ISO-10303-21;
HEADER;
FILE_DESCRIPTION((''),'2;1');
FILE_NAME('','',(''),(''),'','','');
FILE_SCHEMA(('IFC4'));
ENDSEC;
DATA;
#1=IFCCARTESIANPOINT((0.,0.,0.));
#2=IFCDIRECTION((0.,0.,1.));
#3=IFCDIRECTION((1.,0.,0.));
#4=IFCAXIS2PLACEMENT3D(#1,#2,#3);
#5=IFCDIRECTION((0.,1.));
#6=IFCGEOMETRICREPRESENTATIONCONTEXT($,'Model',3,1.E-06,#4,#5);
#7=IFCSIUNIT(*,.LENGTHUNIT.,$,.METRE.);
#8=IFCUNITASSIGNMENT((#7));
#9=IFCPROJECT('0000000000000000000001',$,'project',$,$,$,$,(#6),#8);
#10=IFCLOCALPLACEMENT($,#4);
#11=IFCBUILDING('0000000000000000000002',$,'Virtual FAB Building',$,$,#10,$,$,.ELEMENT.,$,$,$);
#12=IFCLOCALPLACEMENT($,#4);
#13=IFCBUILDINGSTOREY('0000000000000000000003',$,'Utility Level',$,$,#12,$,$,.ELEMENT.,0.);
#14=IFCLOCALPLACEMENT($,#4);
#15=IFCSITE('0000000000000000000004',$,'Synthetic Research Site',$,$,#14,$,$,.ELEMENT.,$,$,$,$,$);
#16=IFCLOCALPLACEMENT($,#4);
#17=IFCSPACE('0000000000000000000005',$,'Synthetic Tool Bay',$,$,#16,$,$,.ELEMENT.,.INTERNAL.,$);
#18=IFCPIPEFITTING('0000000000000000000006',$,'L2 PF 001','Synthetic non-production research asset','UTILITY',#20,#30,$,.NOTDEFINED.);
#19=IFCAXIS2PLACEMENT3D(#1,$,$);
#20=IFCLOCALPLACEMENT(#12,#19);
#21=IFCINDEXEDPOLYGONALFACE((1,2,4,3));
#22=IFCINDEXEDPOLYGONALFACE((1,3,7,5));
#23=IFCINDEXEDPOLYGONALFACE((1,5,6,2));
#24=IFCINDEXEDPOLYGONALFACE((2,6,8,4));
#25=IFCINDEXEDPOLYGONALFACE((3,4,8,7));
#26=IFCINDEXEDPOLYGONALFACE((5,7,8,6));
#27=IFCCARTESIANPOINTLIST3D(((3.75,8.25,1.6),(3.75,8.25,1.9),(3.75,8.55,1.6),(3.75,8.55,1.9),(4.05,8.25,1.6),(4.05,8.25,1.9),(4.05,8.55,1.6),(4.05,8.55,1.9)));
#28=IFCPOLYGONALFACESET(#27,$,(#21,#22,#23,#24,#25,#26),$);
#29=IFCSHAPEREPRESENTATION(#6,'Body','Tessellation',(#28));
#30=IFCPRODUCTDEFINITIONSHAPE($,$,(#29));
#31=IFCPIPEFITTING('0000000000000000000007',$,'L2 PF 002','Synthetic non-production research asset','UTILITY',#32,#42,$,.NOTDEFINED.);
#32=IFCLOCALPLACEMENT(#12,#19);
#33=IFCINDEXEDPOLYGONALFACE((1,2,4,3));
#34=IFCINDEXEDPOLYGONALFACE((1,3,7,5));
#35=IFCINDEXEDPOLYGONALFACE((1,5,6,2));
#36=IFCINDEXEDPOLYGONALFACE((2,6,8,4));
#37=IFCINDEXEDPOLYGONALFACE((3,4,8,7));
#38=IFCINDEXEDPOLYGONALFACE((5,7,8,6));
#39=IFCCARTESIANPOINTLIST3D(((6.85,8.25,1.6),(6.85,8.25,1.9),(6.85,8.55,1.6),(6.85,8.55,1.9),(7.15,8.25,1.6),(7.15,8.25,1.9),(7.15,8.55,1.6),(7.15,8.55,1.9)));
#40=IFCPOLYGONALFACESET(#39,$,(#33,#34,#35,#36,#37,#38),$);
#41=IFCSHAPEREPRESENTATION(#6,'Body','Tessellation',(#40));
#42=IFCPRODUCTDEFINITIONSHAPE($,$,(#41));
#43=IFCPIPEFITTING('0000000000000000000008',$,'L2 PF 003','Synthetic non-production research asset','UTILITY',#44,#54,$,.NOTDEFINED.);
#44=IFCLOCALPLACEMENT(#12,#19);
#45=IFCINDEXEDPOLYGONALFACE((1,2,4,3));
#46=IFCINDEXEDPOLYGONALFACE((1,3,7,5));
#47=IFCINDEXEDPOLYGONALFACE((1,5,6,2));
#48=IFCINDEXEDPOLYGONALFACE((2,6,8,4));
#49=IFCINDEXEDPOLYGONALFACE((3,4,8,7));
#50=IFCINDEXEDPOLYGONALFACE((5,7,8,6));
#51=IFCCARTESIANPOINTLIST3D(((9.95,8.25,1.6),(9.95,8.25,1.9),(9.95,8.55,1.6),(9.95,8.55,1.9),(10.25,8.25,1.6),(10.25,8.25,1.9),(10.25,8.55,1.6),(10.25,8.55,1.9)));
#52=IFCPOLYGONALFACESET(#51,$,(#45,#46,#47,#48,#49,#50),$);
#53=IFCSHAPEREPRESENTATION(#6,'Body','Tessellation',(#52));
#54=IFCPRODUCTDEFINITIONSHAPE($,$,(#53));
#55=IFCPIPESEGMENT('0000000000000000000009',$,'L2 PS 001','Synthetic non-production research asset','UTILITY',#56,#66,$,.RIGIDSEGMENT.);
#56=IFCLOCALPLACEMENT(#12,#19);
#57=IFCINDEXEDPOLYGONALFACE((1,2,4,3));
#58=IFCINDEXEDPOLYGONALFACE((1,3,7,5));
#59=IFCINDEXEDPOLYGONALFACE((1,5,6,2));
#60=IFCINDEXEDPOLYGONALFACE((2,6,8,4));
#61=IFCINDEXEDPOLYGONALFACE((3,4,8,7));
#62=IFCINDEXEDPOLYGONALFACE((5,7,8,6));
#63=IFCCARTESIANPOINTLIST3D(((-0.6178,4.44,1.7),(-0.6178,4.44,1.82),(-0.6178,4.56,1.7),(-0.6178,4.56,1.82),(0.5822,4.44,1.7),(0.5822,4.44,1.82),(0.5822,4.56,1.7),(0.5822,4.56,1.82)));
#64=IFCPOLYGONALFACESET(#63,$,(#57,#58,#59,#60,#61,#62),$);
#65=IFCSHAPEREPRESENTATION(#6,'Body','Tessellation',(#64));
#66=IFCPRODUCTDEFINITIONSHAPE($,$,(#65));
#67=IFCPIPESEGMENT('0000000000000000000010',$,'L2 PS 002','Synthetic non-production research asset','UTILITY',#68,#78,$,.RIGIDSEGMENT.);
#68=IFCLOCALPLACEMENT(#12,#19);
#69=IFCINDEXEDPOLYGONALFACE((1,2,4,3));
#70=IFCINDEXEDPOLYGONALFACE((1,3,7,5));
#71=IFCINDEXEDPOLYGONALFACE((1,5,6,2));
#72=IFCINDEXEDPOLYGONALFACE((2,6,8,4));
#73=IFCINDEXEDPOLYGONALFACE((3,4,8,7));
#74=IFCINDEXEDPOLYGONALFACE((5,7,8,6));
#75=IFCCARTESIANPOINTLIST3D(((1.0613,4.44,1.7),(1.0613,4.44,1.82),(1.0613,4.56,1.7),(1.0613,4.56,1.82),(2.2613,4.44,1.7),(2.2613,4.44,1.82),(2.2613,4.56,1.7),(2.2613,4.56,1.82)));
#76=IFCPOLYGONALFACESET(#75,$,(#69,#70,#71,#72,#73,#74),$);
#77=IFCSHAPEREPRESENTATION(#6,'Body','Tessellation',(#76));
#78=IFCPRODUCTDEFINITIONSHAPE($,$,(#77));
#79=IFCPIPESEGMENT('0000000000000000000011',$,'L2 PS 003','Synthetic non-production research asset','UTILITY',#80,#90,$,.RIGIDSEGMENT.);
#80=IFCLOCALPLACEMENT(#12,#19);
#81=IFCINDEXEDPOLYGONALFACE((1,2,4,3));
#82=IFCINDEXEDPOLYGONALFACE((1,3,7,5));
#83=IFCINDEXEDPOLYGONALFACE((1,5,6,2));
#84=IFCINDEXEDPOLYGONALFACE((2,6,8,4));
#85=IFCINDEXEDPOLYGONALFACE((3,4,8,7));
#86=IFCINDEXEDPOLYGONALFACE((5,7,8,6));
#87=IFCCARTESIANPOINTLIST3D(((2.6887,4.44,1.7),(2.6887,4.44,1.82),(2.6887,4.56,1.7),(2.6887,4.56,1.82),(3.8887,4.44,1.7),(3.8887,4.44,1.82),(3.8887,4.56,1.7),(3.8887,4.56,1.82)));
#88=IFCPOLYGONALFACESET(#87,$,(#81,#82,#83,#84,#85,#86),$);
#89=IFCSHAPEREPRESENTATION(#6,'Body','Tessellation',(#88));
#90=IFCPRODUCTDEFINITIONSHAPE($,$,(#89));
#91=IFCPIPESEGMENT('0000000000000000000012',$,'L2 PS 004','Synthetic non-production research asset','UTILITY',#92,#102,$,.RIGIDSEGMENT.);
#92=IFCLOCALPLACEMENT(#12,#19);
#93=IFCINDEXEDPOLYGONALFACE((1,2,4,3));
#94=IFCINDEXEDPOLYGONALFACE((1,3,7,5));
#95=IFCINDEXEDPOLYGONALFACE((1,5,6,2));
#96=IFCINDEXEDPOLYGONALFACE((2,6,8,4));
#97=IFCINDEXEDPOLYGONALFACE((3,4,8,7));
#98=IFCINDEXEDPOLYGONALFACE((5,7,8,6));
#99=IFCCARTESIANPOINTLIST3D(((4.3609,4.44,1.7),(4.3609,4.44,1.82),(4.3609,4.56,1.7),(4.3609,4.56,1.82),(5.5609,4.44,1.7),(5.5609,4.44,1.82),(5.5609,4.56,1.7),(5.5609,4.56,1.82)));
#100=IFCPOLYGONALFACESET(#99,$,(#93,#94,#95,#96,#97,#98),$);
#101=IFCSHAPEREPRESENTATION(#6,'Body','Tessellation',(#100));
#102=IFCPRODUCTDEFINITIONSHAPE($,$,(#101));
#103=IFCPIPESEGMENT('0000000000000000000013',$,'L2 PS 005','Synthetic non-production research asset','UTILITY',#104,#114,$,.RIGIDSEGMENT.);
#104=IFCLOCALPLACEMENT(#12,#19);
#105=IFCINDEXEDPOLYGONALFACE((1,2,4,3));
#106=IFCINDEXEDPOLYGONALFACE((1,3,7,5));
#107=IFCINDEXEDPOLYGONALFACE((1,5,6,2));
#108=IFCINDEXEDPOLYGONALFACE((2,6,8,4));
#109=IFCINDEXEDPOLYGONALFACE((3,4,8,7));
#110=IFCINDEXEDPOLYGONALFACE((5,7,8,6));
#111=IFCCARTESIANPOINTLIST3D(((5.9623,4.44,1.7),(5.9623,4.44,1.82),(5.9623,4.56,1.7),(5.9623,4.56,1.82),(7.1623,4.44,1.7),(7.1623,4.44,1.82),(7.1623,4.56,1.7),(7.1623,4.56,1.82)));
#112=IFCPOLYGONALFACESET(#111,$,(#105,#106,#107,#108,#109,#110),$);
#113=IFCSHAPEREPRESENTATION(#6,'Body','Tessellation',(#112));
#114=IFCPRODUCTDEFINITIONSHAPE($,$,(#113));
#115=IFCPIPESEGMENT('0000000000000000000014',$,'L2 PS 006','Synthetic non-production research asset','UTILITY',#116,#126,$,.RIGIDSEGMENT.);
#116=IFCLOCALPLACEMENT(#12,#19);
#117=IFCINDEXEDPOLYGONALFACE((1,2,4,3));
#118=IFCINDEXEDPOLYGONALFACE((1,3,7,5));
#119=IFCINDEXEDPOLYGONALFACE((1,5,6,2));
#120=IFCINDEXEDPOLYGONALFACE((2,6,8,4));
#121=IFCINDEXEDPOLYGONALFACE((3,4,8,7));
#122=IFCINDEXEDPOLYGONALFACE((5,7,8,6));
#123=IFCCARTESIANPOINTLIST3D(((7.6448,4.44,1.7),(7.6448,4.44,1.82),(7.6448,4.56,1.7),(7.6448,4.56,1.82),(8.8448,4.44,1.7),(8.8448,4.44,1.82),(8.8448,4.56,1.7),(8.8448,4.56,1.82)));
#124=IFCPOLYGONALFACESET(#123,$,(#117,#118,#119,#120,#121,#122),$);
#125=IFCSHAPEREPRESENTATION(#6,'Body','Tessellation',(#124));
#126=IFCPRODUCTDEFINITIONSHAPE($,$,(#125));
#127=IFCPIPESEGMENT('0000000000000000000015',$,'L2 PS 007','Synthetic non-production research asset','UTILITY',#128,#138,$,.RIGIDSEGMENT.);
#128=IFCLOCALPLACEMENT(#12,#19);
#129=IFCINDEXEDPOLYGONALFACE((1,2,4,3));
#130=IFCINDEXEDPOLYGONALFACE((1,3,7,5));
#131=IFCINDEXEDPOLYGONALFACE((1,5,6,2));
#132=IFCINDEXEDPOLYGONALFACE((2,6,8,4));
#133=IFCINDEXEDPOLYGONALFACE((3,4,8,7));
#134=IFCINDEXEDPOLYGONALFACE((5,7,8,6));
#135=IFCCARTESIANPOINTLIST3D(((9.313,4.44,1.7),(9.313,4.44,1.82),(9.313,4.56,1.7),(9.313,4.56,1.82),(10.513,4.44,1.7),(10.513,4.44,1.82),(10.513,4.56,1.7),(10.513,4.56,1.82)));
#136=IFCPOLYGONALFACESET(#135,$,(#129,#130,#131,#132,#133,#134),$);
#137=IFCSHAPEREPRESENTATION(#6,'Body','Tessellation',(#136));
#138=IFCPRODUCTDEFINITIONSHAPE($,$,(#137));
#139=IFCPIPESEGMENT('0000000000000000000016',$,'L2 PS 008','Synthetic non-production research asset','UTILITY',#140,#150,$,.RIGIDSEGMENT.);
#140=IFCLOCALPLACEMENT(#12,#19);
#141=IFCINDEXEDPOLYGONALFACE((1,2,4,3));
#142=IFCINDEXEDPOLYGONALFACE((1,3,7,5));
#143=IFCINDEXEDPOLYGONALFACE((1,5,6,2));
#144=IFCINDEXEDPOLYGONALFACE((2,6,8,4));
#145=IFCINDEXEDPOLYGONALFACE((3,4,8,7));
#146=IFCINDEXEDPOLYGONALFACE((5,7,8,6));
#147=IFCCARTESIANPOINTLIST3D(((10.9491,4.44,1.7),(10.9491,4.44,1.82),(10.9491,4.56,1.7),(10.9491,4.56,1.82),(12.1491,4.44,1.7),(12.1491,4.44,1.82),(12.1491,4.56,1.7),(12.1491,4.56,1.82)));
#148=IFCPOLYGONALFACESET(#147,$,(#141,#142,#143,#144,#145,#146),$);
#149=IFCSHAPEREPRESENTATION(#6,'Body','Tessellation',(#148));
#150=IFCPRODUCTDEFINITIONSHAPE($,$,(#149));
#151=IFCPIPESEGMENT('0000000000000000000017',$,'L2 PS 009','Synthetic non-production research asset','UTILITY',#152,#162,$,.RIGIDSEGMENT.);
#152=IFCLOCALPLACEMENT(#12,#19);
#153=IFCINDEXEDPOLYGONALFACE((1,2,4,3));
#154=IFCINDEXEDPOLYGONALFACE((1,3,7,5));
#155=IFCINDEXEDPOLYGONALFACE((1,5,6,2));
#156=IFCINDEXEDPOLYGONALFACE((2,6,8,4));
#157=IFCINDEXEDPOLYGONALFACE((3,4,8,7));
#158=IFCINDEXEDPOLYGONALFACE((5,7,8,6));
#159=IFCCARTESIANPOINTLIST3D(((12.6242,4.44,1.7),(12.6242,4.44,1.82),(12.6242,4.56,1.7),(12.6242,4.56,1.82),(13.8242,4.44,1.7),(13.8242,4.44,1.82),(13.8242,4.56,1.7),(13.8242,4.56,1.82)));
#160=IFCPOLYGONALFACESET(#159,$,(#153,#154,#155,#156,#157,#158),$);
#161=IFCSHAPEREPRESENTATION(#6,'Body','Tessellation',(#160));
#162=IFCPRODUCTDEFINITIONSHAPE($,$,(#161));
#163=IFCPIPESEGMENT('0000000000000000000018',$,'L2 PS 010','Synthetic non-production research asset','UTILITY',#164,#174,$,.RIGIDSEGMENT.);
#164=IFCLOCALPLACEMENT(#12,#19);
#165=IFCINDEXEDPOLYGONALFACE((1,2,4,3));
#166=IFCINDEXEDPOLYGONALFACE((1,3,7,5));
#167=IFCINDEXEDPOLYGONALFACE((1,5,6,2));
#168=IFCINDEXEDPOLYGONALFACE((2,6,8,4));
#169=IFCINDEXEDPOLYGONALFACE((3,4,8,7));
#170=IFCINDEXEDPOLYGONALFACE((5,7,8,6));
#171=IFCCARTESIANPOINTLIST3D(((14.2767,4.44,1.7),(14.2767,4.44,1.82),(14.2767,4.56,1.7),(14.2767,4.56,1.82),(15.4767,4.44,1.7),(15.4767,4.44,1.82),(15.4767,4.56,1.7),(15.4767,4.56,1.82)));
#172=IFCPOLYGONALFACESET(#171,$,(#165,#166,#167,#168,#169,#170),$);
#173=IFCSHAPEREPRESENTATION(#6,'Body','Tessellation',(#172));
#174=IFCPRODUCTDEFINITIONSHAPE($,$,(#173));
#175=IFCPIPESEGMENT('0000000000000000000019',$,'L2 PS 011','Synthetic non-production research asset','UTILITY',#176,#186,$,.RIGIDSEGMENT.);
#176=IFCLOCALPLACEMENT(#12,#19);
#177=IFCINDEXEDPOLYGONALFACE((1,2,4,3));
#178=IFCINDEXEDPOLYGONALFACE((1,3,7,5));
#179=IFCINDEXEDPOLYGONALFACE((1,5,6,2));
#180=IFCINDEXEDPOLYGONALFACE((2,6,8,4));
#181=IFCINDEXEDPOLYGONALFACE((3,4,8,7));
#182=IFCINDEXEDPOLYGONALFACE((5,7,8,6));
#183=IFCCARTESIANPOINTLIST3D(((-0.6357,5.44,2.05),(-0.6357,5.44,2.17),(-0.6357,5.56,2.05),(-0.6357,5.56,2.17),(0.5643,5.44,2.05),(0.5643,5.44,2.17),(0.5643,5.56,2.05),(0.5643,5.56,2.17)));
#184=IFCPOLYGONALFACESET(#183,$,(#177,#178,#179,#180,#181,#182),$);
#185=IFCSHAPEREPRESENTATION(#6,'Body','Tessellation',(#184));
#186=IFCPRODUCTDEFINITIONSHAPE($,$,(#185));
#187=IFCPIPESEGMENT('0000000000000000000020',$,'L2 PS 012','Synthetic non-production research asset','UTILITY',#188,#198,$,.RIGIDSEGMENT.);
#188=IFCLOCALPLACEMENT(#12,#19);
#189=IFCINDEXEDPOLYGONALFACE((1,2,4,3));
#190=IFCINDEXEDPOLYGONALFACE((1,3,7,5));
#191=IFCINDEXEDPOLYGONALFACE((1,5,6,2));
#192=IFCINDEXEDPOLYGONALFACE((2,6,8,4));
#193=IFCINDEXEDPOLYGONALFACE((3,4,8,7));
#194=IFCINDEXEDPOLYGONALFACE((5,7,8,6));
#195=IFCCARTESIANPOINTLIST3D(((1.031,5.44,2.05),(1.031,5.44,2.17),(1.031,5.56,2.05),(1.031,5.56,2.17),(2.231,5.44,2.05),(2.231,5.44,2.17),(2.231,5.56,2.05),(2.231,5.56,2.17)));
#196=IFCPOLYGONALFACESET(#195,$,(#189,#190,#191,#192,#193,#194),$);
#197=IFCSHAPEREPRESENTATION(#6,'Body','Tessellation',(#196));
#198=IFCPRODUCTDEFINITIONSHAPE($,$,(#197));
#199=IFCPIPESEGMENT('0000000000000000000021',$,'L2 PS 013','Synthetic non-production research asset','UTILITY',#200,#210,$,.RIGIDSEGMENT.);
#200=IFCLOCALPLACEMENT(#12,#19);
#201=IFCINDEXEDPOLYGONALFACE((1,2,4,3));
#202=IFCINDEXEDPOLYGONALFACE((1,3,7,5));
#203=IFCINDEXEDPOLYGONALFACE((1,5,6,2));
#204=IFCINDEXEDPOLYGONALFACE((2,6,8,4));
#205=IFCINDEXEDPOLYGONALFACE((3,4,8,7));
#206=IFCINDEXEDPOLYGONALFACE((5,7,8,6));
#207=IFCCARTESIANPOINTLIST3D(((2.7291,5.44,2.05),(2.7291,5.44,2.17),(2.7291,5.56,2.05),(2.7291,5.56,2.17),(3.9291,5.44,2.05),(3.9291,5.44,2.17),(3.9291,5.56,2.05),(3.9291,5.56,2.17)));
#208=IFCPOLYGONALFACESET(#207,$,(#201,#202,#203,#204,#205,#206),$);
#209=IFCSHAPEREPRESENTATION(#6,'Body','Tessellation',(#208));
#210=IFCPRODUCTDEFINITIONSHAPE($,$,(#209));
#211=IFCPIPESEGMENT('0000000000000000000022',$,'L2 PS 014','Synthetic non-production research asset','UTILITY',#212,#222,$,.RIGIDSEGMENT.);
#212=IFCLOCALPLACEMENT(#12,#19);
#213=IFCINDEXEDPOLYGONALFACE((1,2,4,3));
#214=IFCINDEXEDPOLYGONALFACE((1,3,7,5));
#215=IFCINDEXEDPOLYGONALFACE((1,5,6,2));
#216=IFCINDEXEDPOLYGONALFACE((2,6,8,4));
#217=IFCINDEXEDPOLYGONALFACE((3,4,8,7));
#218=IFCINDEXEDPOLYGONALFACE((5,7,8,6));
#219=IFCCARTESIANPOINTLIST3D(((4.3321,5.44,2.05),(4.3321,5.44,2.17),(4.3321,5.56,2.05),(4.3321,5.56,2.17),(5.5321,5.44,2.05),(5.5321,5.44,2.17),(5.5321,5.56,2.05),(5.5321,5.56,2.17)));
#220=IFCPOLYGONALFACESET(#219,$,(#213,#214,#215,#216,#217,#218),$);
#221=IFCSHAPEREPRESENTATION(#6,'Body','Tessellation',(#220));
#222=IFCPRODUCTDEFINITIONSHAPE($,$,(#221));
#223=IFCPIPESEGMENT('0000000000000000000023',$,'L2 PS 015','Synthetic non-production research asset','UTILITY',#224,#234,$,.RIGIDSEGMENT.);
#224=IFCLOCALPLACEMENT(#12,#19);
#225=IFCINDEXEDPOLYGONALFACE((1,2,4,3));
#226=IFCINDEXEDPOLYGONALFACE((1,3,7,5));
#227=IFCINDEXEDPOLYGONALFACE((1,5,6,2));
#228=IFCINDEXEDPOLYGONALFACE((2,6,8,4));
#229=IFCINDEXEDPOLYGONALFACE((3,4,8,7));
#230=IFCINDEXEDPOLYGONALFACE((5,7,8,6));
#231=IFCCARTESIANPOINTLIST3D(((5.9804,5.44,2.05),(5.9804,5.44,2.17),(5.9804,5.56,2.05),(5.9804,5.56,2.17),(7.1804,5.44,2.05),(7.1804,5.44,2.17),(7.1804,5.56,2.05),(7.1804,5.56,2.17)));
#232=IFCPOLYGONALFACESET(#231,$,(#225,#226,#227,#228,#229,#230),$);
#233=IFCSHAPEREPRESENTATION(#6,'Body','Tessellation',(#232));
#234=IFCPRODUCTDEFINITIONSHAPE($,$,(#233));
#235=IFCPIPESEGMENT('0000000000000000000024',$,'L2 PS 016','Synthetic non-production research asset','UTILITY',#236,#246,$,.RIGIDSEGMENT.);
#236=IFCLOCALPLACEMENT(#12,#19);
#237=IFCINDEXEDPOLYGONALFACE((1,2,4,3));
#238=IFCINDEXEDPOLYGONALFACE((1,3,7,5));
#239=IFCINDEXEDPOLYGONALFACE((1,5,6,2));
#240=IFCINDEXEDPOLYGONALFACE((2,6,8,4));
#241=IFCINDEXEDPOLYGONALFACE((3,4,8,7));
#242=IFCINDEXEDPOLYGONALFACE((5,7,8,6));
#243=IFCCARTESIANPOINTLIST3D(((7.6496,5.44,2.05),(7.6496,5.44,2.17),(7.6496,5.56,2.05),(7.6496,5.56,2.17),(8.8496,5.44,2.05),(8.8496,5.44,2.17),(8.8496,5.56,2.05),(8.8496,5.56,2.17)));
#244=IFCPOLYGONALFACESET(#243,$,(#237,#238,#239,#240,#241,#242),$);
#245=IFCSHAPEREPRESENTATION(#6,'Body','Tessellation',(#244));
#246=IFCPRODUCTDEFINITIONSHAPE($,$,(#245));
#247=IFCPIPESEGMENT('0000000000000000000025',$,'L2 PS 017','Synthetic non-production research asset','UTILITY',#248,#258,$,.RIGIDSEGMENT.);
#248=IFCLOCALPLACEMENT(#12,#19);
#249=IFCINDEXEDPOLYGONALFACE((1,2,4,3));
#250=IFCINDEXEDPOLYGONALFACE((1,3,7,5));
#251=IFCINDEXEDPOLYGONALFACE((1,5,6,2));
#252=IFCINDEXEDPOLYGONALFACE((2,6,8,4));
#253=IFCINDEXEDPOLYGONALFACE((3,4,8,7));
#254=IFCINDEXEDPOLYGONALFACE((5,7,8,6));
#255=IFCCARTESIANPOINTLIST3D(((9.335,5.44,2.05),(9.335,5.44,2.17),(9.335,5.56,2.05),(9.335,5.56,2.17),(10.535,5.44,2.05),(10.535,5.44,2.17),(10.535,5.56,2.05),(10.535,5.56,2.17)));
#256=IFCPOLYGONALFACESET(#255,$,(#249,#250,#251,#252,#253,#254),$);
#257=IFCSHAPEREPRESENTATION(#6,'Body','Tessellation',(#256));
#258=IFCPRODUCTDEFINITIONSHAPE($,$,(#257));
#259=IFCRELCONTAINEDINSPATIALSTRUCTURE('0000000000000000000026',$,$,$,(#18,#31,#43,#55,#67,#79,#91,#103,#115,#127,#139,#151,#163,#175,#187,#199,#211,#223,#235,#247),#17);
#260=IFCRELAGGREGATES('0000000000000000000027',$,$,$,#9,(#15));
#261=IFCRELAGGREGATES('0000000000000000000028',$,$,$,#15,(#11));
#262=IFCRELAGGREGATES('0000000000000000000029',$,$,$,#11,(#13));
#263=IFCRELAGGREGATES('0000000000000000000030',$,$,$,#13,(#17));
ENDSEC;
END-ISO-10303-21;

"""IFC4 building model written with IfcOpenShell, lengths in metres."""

from ifc_helpers import new_model, si_unit, direction, frame, origin_with_axes, origin_2d_with_axis, place, context, project, spatial, rectangle, extrude, element, save


model = new_model("IFC4")

# Units and contexts
model_context = context("Model", 3, precision=1e-06, world=origin_with_axes(), true_north=direction((0.0, 1.0)))
ifc_project = project(units=[si_unit("LENGTHUNIT", "METRE")], contexts=[model_context])

# Site, building, storey, space
site_placement = place(None, origin_with_axes())
site = spatial("IfcSite", under=ifc_project, at=site_placement, Name="Synthetic Research Site", CompositionType="ELEMENT")
building_placement = place(None, origin_with_axes())
building = spatial("IfcBuilding", under=site, at=building_placement, Name="Virtual FAB Building", CompositionType="ELEMENT")
storey_placement = place(None, origin_with_axes())
storey = spatial("IfcBuildingStorey", under=building, at=storey_placement, Name="Utility Level", CompositionType="ELEMENT", Elevation=0.0)
space_placement = place(None, origin_with_axes())
space = spatial("IfcSpace", under=storey, at=space_placement, Name="Synthetic Tool Bay", CompositionType="ELEMENT", PredefinedType="INTERNAL")

# Pipe fittings
for number, where, z_axis, x_axis, name in (
    (1, (3.9, 8.4, 1.6), (0.0, 0.0, 1.0), (1.0, 0.0, 0.0), "L2 PF 001"),
    (2, (7.0, 8.4, 1.6), (0.0, 0.0, 1.0), (1.0, 0.0, 0.0), "L2 PF 002"),
    (3, (10.1, 8.4, 1.6), (0.0, 0.0, 1.0), (1.0, 0.0, 0.0), "L2 PF 003"),
):
    element("IfcPipeFitting", number, at=place(None, frame(where, z_axis=z_axis, x_axis=x_axis)), inside=space, Name=name, Description="Synthetic non-production research asset", ObjectType="UTILITY", PredefinedType="NOTDEFINED", context=model_context, shape_type="SweptSolid", body=[
        extrude(rectangle(XDim=0.3, YDim=0.3, at=origin_2d_with_axis()), origin_with_axes(), (0.0, 0.0, 1.0), 0.3),
    ])

# Pipe segments
for number, where, z_axis, x_axis, name in (
    (4, (-0.0178, 4.5, 1.7), (0.0, 0.0, 1.0), (1.0, 0.0, 0.0), "L2 PS 001"),
    (5, (1.6613, 4.5, 1.7), (0.0, 0.0, 1.0), (1.0, 0.0, 0.0), "L2 PS 002"),
    (6, (3.2887, 4.5, 1.7), (0.0, 0.0, 1.0), (1.0, 0.0, 0.0), "L2 PS 003"),
    (7, (4.9609, 4.5, 1.7), (0.0, 0.0, 1.0), (1.0, 0.0, 0.0), "L2 PS 004"),
    (8, (6.5623, 4.5, 1.7), (0.0, 0.0, 1.0), (1.0, 0.0, 0.0), "L2 PS 005"),
    (9, (8.2448, 4.5, 1.7), (0.0, 0.0, 1.0), (1.0, 0.0, 0.0), "L2 PS 006"),
    (10, (9.913, 4.5, 1.7), (0.0, 0.0, 1.0), (1.0, 0.0, 0.0), "L2 PS 007"),
    (11, (11.5491, 4.5, 1.7), (0.0, 0.0, 1.0), (1.0, 0.0, 0.0), "L2 PS 008"),
    (12, (13.2242, 4.5, 1.7), (0.0, 0.0, 1.0), (1.0, 0.0, 0.0), "L2 PS 009"),
    (13, (14.8767, 4.5, 1.7), (0.0, 0.0, 1.0), (1.0, 0.0, 0.0), "L2 PS 010"),
    (14, (-0.0357, 5.5, 2.05), (0.0, 0.0, 1.0), (1.0, 0.0, 0.0), "L2 PS 011"),
    (15, (1.631, 5.5, 2.05), (0.0, 0.0, 1.0), (1.0, 0.0, 0.0), "L2 PS 012"),
    (16, (3.3291, 5.5, 2.05), (0.0, 0.0, 1.0), (1.0, 0.0, 0.0), "L2 PS 013"),
    (17, (4.9321, 5.5, 2.05), (0.0, 0.0, 1.0), (1.0, 0.0, 0.0), "L2 PS 014"),
    (18, (6.5804, 5.5, 2.05), (0.0, 0.0, 1.0), (1.0, 0.0, 0.0), "L2 PS 015"),
    (19, (8.2496, 5.5, 2.05), (0.0, 0.0, 1.0), (1.0, 0.0, 0.0), "L2 PS 016"),
    (20, (9.935, 5.5, 2.05), (0.0, 0.0, 1.0), (1.0, 0.0, 0.0), "L2 PS 017"),
):
    element("IfcPipeSegment", number, at=place(None, frame(where, z_axis=z_axis, x_axis=x_axis)), inside=space, Name=name, Description="Synthetic non-production research asset", ObjectType="UTILITY", PredefinedType="RIGIDSEGMENT", context=model_context, shape_type="SweptSolid", body=[
        extrude(rectangle(XDim=1.2, YDim=0.12, at=origin_2d_with_axis()), origin_with_axes(), (0.0, 0.0, 1.0), 0.12),
    ])

save(model, "model.ifc")
